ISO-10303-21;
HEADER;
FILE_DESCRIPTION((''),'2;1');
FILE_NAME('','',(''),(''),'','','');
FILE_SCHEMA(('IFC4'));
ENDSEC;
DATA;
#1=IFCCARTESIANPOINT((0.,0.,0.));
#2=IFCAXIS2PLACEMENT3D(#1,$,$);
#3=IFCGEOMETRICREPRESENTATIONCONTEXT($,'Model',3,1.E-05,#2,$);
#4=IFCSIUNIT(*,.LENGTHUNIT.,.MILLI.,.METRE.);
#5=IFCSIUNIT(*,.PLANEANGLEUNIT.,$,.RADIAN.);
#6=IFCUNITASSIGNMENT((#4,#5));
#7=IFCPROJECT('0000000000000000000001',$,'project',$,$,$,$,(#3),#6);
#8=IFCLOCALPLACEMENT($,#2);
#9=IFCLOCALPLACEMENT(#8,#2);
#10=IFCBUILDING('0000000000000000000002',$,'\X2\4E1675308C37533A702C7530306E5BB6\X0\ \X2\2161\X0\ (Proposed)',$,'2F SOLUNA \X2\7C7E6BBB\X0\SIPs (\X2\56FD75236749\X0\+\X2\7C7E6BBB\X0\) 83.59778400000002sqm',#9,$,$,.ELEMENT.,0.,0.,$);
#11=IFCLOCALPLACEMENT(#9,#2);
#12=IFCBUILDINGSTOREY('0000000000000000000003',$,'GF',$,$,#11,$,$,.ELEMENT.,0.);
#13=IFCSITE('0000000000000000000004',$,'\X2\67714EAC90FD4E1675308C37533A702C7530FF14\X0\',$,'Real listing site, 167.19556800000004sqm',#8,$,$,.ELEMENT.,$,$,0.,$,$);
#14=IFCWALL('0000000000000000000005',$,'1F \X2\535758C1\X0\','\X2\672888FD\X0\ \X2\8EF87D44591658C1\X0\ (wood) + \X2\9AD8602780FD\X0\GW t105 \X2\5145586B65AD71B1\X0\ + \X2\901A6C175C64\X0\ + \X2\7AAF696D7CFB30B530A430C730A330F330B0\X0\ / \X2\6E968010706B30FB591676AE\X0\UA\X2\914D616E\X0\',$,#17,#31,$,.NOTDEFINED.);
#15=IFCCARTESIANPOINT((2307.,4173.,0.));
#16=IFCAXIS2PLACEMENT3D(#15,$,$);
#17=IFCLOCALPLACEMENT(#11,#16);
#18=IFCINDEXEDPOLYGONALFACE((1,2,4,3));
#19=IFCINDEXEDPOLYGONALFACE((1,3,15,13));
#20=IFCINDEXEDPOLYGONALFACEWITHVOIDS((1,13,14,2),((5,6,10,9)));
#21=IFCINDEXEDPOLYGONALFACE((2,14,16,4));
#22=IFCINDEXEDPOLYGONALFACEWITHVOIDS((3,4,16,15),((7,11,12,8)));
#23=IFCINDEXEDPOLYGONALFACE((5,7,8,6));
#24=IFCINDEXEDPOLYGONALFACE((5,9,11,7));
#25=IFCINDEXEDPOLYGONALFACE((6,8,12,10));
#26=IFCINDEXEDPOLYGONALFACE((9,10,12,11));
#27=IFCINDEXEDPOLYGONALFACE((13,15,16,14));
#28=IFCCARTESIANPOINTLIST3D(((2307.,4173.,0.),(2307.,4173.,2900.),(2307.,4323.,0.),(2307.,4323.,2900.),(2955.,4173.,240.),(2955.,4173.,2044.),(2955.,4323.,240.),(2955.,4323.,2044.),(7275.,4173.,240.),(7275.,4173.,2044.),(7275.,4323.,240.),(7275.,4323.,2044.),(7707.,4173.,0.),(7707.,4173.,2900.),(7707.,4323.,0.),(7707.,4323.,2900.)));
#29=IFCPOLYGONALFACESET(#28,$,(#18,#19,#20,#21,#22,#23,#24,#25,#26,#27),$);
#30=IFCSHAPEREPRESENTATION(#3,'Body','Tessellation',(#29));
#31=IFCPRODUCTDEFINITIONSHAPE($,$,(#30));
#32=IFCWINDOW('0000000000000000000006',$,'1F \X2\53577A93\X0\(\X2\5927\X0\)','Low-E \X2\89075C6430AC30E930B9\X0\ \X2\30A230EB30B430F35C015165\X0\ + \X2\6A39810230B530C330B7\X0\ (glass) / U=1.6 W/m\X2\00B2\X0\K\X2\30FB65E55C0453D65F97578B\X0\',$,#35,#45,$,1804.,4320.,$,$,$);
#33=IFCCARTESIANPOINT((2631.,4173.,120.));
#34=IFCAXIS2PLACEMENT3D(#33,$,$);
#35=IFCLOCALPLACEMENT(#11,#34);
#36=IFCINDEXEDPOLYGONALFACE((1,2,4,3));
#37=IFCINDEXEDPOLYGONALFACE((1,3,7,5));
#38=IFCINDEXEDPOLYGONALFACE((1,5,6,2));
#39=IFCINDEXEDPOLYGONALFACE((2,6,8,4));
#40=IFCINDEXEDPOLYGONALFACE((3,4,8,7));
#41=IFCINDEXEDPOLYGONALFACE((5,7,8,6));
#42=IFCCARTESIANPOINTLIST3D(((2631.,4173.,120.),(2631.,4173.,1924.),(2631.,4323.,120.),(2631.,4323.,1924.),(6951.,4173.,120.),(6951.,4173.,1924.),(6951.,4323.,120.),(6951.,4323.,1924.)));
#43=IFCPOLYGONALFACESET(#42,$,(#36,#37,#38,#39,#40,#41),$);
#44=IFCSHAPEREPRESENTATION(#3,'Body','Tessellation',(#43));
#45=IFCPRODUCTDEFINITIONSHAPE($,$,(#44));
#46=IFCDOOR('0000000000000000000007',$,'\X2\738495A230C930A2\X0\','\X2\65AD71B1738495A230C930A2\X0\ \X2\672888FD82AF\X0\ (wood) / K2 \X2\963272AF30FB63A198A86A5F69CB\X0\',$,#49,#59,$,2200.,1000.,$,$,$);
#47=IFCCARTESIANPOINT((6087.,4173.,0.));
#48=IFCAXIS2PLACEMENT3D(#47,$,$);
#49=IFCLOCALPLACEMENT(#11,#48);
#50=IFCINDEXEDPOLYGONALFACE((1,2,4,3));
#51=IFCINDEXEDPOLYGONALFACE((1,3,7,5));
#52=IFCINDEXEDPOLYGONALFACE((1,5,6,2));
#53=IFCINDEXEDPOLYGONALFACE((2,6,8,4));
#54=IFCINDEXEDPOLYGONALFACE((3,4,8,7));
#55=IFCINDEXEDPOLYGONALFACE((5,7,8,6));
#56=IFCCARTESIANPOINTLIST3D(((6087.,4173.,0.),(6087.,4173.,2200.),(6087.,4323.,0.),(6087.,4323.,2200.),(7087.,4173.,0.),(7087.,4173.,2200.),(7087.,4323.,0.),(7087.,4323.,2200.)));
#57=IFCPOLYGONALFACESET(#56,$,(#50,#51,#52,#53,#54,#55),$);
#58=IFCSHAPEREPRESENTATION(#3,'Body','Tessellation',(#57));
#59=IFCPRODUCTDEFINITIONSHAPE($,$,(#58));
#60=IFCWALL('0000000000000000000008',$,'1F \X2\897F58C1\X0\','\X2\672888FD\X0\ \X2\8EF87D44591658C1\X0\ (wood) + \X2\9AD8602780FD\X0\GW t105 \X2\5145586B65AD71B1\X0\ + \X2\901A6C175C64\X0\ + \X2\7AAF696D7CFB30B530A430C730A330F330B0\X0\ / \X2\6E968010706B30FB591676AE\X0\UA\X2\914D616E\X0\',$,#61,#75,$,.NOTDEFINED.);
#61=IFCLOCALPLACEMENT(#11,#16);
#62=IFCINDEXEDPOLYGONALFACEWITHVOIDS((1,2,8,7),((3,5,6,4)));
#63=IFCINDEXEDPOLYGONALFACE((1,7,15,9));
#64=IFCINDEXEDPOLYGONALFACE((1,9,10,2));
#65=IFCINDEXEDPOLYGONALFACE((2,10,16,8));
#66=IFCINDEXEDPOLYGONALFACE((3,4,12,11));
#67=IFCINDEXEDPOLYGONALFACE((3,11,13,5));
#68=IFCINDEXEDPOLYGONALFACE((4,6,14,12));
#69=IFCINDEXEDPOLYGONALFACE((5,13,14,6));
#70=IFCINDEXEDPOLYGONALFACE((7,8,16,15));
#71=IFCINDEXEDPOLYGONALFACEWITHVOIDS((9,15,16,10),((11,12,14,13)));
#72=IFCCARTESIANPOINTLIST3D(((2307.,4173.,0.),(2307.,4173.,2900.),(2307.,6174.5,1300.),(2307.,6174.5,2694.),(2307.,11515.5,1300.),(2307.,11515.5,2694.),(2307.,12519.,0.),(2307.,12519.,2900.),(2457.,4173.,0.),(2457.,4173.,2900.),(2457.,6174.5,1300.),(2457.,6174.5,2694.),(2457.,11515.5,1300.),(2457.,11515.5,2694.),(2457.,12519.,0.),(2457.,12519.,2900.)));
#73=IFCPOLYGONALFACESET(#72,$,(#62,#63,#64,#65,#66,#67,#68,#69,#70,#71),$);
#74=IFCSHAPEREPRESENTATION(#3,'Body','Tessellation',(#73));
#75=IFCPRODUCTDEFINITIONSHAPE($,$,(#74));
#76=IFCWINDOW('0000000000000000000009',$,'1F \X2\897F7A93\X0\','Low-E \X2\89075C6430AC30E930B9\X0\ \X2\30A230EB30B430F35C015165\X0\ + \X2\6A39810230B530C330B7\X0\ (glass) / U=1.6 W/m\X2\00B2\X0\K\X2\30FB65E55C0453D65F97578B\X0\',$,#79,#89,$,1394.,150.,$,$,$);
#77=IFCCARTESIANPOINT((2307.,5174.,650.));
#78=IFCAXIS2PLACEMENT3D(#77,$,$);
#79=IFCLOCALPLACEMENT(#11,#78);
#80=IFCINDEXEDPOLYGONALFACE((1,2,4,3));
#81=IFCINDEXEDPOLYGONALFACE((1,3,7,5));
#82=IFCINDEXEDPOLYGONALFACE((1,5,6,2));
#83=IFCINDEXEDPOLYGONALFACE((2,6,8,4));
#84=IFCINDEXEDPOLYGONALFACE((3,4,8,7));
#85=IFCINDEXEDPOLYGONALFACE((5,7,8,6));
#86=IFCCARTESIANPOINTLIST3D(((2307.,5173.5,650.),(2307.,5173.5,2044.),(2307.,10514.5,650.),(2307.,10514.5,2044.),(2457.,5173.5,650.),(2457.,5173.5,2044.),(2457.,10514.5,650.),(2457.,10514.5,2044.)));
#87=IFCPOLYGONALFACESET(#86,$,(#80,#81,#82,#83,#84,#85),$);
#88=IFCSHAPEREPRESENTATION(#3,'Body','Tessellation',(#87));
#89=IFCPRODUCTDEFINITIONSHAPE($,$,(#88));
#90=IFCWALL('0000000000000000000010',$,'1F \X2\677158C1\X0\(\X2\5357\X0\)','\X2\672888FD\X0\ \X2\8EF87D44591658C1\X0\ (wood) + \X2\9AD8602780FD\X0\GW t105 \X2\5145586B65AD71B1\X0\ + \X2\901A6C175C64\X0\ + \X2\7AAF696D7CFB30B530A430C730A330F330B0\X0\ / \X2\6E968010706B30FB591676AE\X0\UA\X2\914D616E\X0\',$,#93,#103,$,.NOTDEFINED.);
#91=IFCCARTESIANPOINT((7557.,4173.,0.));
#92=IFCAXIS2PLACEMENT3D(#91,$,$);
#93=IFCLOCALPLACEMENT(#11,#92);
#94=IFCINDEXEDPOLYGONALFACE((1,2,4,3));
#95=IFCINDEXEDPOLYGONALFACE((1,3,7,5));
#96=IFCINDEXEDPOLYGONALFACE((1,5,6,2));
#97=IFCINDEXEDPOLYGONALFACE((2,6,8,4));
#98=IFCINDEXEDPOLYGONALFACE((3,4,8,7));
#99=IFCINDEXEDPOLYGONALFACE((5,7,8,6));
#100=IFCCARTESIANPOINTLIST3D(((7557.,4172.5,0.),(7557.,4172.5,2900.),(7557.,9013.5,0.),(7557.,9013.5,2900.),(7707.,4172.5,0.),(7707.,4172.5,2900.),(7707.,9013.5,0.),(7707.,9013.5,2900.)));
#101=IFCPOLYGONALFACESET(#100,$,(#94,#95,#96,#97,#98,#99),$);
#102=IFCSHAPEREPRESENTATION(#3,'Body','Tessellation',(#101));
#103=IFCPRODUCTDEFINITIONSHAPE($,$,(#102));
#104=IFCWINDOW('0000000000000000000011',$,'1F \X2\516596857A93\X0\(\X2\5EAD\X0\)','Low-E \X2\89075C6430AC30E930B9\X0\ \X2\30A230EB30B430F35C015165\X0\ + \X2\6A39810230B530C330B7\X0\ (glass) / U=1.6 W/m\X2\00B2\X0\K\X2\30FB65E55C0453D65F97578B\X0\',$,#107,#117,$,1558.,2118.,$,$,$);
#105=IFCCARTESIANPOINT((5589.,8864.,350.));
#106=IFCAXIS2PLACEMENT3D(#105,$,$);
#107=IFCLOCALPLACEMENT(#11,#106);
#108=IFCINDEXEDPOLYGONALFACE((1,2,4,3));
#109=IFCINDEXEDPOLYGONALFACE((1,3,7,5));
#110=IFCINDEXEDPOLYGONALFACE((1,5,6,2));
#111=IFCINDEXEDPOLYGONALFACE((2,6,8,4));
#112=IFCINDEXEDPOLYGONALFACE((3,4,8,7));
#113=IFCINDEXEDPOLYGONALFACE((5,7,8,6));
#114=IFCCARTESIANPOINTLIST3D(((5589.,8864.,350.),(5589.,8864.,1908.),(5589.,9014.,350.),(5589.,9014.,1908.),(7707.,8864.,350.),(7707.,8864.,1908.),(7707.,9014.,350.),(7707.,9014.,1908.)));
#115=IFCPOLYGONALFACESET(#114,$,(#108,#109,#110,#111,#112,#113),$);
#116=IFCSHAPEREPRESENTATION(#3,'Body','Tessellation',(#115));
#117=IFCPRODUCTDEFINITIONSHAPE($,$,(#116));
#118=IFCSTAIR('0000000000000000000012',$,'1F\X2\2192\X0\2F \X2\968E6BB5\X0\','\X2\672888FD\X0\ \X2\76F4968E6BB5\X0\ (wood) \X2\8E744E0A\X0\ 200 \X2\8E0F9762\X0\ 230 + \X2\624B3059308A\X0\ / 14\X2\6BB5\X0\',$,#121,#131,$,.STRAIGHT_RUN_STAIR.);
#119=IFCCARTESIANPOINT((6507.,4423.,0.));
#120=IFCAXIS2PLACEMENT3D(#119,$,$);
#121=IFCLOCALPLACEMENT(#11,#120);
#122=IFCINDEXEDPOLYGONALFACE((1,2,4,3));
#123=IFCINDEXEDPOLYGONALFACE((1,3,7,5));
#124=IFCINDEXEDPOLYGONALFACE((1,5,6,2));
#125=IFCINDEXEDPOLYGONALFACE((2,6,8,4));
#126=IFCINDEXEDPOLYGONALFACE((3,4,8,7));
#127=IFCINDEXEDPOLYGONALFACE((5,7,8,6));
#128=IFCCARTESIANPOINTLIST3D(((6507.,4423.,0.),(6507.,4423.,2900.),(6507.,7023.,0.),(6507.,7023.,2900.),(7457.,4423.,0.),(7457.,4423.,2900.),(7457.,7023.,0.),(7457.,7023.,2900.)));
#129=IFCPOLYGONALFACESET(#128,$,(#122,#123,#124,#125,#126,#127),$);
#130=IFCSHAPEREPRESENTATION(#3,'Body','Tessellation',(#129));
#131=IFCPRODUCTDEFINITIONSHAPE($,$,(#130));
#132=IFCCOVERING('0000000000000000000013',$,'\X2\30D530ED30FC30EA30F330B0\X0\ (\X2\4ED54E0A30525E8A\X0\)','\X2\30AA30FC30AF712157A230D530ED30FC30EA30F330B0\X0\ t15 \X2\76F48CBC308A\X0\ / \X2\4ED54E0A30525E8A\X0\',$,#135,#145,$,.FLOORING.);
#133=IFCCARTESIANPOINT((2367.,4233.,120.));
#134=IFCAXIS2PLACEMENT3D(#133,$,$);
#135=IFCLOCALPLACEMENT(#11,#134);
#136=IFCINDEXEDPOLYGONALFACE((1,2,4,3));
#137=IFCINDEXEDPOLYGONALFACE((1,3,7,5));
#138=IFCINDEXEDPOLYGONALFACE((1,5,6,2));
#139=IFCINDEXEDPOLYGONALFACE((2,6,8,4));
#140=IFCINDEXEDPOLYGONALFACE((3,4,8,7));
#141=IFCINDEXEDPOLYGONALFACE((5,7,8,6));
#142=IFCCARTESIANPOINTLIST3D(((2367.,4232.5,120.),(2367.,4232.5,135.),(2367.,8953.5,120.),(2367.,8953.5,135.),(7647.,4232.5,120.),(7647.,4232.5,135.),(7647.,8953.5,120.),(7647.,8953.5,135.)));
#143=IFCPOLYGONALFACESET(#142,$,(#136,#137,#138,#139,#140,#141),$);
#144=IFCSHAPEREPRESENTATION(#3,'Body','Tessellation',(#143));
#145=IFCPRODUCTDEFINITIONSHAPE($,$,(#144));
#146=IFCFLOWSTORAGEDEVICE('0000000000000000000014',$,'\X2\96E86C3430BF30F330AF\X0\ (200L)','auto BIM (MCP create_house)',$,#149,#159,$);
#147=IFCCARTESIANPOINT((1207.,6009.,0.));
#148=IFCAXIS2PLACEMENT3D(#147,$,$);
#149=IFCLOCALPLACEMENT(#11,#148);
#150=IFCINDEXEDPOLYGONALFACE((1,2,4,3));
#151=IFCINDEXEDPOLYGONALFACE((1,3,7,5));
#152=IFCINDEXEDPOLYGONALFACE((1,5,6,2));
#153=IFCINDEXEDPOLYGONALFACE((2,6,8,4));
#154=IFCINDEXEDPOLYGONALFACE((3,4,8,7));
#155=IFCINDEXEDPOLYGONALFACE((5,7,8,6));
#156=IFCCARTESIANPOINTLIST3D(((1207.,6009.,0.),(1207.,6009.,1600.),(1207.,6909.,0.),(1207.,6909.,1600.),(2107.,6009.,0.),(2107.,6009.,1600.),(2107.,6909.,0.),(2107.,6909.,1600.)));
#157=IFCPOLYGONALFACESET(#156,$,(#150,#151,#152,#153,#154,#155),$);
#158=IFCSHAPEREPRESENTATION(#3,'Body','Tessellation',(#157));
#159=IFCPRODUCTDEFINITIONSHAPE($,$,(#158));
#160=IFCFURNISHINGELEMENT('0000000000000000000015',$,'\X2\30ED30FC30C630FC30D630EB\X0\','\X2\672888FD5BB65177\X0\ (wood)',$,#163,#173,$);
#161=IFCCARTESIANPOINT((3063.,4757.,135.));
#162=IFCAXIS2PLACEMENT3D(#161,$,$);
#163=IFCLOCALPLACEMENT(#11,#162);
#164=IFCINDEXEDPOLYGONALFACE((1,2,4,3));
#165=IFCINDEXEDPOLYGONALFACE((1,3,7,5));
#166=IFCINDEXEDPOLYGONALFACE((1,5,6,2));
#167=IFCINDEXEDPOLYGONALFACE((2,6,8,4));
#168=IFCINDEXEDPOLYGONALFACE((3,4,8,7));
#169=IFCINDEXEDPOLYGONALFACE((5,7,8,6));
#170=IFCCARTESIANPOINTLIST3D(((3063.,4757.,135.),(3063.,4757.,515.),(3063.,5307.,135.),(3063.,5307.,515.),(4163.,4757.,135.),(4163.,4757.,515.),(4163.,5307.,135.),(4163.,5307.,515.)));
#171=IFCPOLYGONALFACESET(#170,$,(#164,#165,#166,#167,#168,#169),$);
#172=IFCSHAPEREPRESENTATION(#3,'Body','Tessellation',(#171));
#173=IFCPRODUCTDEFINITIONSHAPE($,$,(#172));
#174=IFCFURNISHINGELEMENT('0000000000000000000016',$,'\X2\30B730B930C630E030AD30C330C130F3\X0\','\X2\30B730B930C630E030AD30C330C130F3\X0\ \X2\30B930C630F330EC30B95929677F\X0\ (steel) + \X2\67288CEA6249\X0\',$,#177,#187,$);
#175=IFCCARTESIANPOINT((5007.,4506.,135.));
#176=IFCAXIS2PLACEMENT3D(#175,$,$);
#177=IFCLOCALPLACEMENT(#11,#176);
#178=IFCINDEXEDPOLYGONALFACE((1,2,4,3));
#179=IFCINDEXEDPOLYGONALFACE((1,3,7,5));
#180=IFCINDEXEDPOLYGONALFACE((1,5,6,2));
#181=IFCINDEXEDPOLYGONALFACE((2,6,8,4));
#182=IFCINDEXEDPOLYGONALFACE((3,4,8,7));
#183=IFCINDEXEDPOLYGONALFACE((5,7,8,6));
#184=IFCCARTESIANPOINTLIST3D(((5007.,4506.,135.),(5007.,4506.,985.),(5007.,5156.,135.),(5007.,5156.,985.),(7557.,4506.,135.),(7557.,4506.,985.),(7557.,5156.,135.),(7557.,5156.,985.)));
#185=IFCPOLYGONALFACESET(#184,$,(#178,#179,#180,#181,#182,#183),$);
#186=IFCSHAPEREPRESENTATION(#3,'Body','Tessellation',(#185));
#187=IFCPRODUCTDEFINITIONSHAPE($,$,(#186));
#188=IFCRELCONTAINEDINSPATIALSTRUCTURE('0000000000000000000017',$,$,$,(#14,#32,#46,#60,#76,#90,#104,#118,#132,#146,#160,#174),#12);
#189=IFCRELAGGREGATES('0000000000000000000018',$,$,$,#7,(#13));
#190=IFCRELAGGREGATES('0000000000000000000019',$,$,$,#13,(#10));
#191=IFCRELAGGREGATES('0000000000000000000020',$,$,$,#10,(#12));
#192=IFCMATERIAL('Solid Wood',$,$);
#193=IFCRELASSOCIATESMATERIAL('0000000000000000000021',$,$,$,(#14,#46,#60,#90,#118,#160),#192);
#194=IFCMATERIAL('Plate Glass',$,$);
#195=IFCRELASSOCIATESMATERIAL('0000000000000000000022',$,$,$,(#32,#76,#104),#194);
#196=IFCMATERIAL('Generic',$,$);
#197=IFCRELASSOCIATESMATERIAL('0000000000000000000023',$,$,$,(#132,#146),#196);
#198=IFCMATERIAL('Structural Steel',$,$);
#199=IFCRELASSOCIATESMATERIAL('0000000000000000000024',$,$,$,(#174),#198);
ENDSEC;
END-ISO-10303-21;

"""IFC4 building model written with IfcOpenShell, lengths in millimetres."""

from ifc_helpers import new_model, si_unit, frame, frame_2d, origin, place, context, project, spatial, rectangle, extrude, material, element, fill, save


model = new_model("IFC4")

# Units and contexts
model_context = context("Model", 3, precision=1e-05, world=origin())
ifc_project = project(units=[si_unit("LENGTHUNIT", "METRE", prefix="MILLI"), si_unit("PLANEANGLEUNIT", "RADIAN")], contexts=[model_context])

# Site, building, storey
site_placement = place(None, origin())
site = spatial("IfcSite", under=ifc_project, at=site_placement, Name="東京都世田谷区瀬田４", ObjectType="Real listing site, 167.19556800000004sqm", CompositionType="ELEMENT", RefElevation=0.0)
building_placement = place(site_placement, origin())
building = spatial("IfcBuilding", under=site, at=building_placement, Name="世田谷区瀬田の家 Ⅱ (Proposed)", ObjectType="2F SOLUNA 籾殻SIPs (国産杉+籾殻) 83.59778400000002sqm", CompositionType="ELEMENT", ElevationOfRefHeight=0.0, ElevationOfTerrain=0.0)
storey_placement = place(building_placement, origin())
storey = spatial("IfcBuildingStorey", under=building, at=storey_placement, Name="GF", CompositionType="ELEMENT", Elevation=0.0)

# Shared definitions
ifc_material_1 = material(Name="Solid Wood")

# Wall, openings, window, door
wall_1_placement = place(storey_placement, frame((2307.0, 4173.0, 0.0)))
wall_1 = element("IfcWall", 1, at=wall_1_placement, inside=storey, material=ifc_material_1, Name="1F 南壁", Description="木製 軸組外壁 (wood) + 高性能GW t105 充填断熱 + 通気層 + 窯業系サイディング / 準耐火・外皮UA配慮", PredefinedType="NOTDEFINED", context=model_context, shape_type="SweptSolid", body=[
    extrude(rectangle(XDim=5400.0, YDim=150.0, at=frame_2d((2700.0, 75.0))), frame((2307.0, 4173.0, 0.0)), (0.0, 0.0, 1.0), 2900.0),
])
opening_1_placement = place(storey_placement, frame((2631.0, 4173.0, 120.0)))
opening_1 = element("IfcOpeningElement", 2, at=opening_1_placement, cuts=wall_1, PredefinedType="NOTDEFINED", context=model_context, shape_type="SweptSolid", body=[
    extrude(rectangle(XDim=4320.0, YDim=150.0, at=frame_2d((2160.0, 75.0))), frame((2631.0, 4173.0, 120.0)), (0.0, 0.0, 1.0), 1804.0),
])
opening_2_placement = place(storey_placement, frame((6087.0, 4173.0, 0.0)))
opening_2 = element("IfcOpeningElement", 3, at=opening_2_placement, cuts=wall_1, PredefinedType="NOTDEFINED", context=model_context, shape_type="SweptSolid", body=[
    extrude(rectangle(XDim=1000.0, YDim=150.0, at=frame_2d((500.0, 75.0))), frame((6087.0, 4173.0, 0.0)), (0.0, 0.0, 1.0), 2200.0),
])
ifc_material_2 = material(Name="Plate Glass")
window_1_placement = place(storey_placement, frame((2631.0, 4173.0, 120.0)))
window_1 = element("IfcWindow", 4, at=window_1_placement, inside=storey, material=ifc_material_2, Name="1F 南窓(大)", Description="Low-E 複層ガラス アルゴン封入 + 樹脂サッシ (glass) / U=1.6 W/m²K・日射取得型", OverallHeight=1804.0, OverallWidth=4320.0, context=model_context, shape_type="SweptSolid", body=[
    extrude(rectangle(XDim=4320.0, YDim=150.0, at=frame_2d((2160.0, 75.0))), frame((2631.0, 4173.0, 120.0)), (0.0, 0.0, 1.0), 1804.0),
])
fill(opening_1, window_1)
door_1_placement = place(storey_placement, frame((6087.0, 4173.0, 0.0)))
door_1 = element("IfcDoor", 5, at=door_1_placement, inside=storey, material=ifc_material_1, Name="玄関ドア", Description="断熱玄関ドア 木製芯 (wood) / K2 防犯・採風機構", OverallHeight=2200.0, OverallWidth=1000.0, context=model_context, shape_type="SweptSolid", body=[
    extrude(rectangle(XDim=1000.0, YDim=150.0, at=frame_2d((500.0, 75.0))), frame((6087.0, 4173.0, 0.0)), (0.0, 0.0, 1.0), 2200.0),
])
fill(opening_2, door_1)

# Walls, openings, windows
wall_2_placement = place(storey_placement, frame((2307.0, 4173.0, 0.0)))
wall_2 = element("IfcWall", 6, at=wall_2_placement, inside=storey, material=ifc_material_1, Name="1F 西壁", Description="木製 軸組外壁 (wood) + 高性能GW t105 充填断熱 + 通気層 + 窯業系サイディング / 準耐火・外皮UA配慮", PredefinedType="NOTDEFINED", context=model_context, shape_type="SweptSolid", body=[
    extrude(rectangle(XDim=150.0, YDim=8346.0, at=frame_2d((75.0, 4173.0))), frame((2307.0, 4173.0, 0.0)), (0.0, 0.0, 1.0), 2900.0),
])
opening_3_placement = place(storey_placement, frame((2307.0, 5174.0, 650.0)))
opening_3 = element("IfcOpeningElement", 7, at=opening_3_placement, cuts=wall_2, PredefinedType="NOTDEFINED", context=model_context, shape_type="SweptSolid", body=[
    extrude(rectangle(XDim=150.0, YDim=5341.0, at=frame_2d((75.0, 2670.0))), frame((2307.0, 5174.0, 650.0)), (0.0, 0.0, 1.0), 1394.0),
])
window_2_placement = place(storey_placement, frame((2307.0, 5174.0, 650.0)))
window_2 = element("IfcWindow", 8, at=window_2_placement, inside=storey, material=ifc_material_2, Name="1F 西窓", Description="Low-E 複層ガラス アルゴン封入 + 樹脂サッシ (glass) / U=1.6 W/m²K・日射取得型", OverallHeight=1394.0, OverallWidth=150.0, context=model_context, shape_type="SweptSolid", body=[
    extrude(rectangle(XDim=150.0, YDim=5341.0, at=frame_2d((75.0, 2670.0))), frame((2307.0, 5174.0, 650.0)), (0.0, 0.0, 1.0), 1394.0),
])
fill(opening_3, window_2)
wall_3_placement = place(storey_placement, frame((7557.0, 4173.0, 0.0)))
wall_3 = element("IfcWall", 9, at=wall_3_placement, inside=storey, material=ifc_material_1, Name="1F 東壁(南)", Description="木製 軸組外壁 (wood) + 高性能GW t105 充填断熱 + 通気層 + 窯業系サイディング / 準耐火・外皮UA配慮", PredefinedType="NOTDEFINED", context=model_context, shape_type="SweptSolid", body=[
    extrude(rectangle(XDim=150.0, YDim=4841.0, at=frame_2d((75.0, 2420.0))), frame((7557.0, 4173.0, 0.0)), (0.0, 0.0, 1.0), 2900.0),
])
opening_4_placement = place(storey_placement, frame((5589.0, 8864.0, 350.0)))
opening_4 = element("IfcOpeningElement", 10, at=opening_4_placement, cuts=wall_3, PredefinedType="NOTDEFINED", context=model_context, shape_type="SweptSolid", body=[
    extrude(rectangle(XDim=2118.0, YDim=150.0, at=frame_2d((1059.0, 75.0))), frame((5589.0, 8864.0, 350.0)), (0.0, 0.0, 1.0), 1558.0),
])
window_3_placement = place(storey_placement, frame((5589.0, 8864.0, 350.0)))
window_3 = element("IfcWindow", 11, at=window_3_placement, inside=storey, material=ifc_material_2, Name="1F 入隅窓(庭)", Description="Low-E 複層ガラス アルゴン封入 + 樹脂サッシ (glass) / U=1.6 W/m²K・日射取得型", OverallHeight=1558.0, OverallWidth=2118.0, context=model_context, shape_type="SweptSolid", body=[
    extrude(rectangle(XDim=2118.0, YDim=150.0, at=frame_2d((1059.0, 75.0))), frame((5589.0, 8864.0, 350.0)), (0.0, 0.0, 1.0), 1558.0),
])
fill(opening_4, window_3)

# Stair
stair_placement = place(storey_placement, frame((6507.0, 4423.0, 0.0)))
element("IfcStair", 12, at=stair_placement, inside=storey, material=ifc_material_1, Name="1F→2F 階段", Description="木製 直階段 (wood) 蹴上 200 踏面 230 + 手すり / 14段", PredefinedType="STRAIGHT_RUN_STAIR", context=model_context, shape_type="SweptSolid", body=[
    extrude(rectangle(XDim=950.0, YDim=2600.0, at=frame_2d((475.0, 1300.0))), frame((6507.0, 4423.0, 0.0)), (0.0, 0.0, 1.0), 2900.0),
])

# Covering
ifc_material_3 = material(Name="Generic")
covering_placement = place(storey_placement, frame((2367.0, 4233.0, 120.0)))
element("IfcCovering", 13, at=covering_placement, inside=storey, material=ifc_material_3, Name="フローリング (仕上げ床)", Description="オーク無垢フローリング t15 直貼り / 仕上げ床", PredefinedType="FLOORING", context=model_context, shape_type="SweptSolid", body=[
    extrude(rectangle(XDim=5280.0, YDim=4721.0, at=frame_2d((2640.0, 2360.0))), frame((2367.0, 4233.0, 120.0)), (0.0, 0.0, 1.0), 15.0),
])

# Flow storage device
flow_storage_device_placement = place(storey_placement, frame((1207.0, 6009.0, 0.0)))
element("IfcFlowStorageDevice", 14, at=flow_storage_device_placement, inside=storey, material=ifc_material_3, Name="雨水タンク (200L)", Description="auto BIM (MCP create_house)", context=model_context, shape_type="SweptSolid", body=[
    extrude(rectangle(XDim=900.0, YDim=900.0, at=frame_2d((450.0, 450.0))), frame((1207.0, 6009.0, 0.0)), (0.0, 0.0, 1.0), 1600.0),
])

# Furnishing elements
furnishing_1_placement = place(storey_placement, frame((3063.0, 4757.0, 135.0)))
element("IfcFurnishingElement", 15, at=furnishing_1_placement, inside=storey, material=ifc_material_1, Name="ローテーブル", Description="木製家具 (wood)", context=model_context, shape_type="SweptSolid", body=[
    extrude(rectangle(XDim=1100.0, YDim=550.0, at=frame_2d((550.0, 275.0))), frame((3063.0, 4757.0, 135.0)), (0.0, 0.0, 1.0), 380.0),
])
ifc_material_4 = material(Name="Structural Steel")
furnishing_2_placement = place(storey_placement, frame((5007.0, 4506.0, 135.0)))
element("IfcFurnishingElement", 16, at=furnishing_2_placement, inside=storey, material=ifc_material_4, Name="システムキッチン", Description="システムキッチン ステンレス天板 (steel) + 木質扉", context=model_context, shape_type="SweptSolid", body=[
    extrude(rectangle(XDim=2550.0, YDim=650.0, at=frame_2d((1275.0, 325.0))), frame((5007.0, 4506.0, 135.0)), (0.0, 0.0, 1.0), 850.0),
])

save(model, "model.ifc")
